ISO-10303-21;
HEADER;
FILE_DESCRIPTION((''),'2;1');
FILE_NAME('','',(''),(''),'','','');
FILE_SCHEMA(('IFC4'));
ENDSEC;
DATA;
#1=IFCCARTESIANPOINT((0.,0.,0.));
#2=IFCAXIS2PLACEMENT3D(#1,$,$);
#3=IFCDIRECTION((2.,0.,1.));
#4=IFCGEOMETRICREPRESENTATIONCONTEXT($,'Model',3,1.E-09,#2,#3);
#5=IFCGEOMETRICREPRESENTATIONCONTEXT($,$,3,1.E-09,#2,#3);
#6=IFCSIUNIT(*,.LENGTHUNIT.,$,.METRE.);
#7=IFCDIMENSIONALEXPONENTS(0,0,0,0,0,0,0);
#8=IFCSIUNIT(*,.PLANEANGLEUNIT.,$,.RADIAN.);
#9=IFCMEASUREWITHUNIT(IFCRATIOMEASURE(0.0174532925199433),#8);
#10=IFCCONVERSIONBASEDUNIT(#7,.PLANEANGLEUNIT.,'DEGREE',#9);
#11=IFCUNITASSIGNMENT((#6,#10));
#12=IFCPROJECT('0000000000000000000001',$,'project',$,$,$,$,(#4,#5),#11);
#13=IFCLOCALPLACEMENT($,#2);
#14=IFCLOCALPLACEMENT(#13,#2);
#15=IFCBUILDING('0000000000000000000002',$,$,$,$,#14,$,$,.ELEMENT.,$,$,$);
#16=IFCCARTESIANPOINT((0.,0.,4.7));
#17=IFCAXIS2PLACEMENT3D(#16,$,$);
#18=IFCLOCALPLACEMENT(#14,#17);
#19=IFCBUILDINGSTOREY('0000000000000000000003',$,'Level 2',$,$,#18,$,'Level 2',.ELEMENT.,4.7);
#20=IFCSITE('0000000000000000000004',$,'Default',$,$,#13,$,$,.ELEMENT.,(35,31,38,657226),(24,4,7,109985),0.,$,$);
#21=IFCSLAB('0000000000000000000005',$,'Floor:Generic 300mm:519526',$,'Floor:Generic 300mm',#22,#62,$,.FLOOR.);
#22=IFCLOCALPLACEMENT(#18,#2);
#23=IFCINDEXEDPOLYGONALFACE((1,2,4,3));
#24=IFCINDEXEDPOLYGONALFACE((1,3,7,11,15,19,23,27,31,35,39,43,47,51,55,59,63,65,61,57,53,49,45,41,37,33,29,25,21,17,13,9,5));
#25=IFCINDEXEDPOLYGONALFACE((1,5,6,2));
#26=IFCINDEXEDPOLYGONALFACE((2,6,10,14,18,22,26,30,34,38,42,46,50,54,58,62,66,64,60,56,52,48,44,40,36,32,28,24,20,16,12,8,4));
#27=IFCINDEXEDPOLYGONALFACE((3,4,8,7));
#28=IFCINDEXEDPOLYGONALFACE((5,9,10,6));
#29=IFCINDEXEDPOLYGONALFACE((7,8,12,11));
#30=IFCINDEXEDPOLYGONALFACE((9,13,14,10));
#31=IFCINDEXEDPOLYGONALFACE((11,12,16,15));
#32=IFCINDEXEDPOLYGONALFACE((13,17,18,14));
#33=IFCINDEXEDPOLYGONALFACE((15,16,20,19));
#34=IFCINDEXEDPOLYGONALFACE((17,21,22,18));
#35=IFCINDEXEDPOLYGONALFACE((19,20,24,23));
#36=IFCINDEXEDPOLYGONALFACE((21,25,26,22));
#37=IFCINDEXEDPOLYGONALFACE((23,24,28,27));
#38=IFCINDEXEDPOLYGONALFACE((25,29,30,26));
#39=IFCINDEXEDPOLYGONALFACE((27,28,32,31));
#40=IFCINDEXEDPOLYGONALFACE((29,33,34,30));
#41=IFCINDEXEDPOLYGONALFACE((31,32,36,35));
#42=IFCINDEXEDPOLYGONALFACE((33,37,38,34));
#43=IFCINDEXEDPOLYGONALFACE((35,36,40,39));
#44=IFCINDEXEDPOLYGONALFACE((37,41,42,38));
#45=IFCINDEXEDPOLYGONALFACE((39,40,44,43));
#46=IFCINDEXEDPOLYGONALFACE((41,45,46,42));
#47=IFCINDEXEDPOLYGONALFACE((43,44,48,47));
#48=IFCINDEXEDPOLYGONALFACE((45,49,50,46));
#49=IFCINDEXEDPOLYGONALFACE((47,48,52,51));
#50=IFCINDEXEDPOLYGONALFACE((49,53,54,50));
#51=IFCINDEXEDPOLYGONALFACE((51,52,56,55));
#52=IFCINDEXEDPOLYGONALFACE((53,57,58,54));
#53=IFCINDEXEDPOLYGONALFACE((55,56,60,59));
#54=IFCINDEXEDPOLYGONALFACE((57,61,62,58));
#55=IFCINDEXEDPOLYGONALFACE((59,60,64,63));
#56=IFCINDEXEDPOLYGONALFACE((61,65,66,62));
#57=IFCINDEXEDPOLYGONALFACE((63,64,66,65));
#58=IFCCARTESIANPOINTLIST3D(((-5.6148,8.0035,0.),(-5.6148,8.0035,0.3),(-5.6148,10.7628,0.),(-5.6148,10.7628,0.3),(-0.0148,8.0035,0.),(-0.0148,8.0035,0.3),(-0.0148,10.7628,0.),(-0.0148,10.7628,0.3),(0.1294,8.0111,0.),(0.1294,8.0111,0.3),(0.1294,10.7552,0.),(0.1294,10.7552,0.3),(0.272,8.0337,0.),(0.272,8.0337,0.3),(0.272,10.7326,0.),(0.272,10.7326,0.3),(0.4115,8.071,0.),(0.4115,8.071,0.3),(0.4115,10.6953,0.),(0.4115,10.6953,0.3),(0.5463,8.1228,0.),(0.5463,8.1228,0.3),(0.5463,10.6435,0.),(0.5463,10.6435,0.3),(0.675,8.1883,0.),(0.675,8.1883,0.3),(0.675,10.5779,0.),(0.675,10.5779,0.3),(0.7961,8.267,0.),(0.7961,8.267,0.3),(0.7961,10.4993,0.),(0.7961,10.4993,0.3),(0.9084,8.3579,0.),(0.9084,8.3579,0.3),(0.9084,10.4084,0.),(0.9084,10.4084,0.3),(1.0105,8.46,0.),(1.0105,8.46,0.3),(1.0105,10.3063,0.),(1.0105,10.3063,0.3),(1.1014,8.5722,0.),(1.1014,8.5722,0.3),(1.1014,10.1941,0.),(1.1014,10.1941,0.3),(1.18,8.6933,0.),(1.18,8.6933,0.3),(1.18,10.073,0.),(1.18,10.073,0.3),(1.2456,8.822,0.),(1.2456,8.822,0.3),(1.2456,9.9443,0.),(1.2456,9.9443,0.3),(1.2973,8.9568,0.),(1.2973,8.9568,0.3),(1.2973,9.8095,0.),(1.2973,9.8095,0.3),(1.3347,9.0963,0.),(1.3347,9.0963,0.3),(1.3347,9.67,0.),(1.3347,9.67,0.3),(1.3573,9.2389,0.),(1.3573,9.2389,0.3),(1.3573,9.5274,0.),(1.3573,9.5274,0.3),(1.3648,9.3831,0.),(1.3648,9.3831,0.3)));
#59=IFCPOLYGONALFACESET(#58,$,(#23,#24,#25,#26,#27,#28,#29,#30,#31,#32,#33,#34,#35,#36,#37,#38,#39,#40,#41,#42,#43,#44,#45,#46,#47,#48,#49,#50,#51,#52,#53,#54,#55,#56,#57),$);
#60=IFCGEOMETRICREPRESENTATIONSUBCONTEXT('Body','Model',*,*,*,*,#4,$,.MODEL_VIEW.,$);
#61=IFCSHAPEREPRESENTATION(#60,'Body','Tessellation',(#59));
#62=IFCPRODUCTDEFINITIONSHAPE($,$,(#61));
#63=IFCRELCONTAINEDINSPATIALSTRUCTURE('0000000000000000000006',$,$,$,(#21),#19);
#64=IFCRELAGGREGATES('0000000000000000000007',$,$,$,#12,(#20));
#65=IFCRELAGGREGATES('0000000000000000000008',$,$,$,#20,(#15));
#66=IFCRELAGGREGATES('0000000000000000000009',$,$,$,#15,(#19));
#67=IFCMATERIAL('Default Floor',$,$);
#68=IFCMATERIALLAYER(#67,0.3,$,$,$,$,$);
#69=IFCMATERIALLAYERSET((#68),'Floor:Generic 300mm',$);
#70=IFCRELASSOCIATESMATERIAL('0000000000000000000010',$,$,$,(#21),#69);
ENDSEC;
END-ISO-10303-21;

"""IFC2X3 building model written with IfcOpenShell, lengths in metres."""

from ifc_helpers import new_model, entity, si_unit, converted_unit, direction, frame, frame_2d, origin, place, context, subcontext, project, spatial, polyline, circle_curve, parameter, trimmed, segment, composite_curve, outline, extrude, material, layer, layer_set, layer_usage, element, save


model = new_model("IFC2X3")

# Units and contexts
model_context = context("Model", 3, precision=1e-09, world=origin(), true_north=direction((2.0, 0.0, 1.0)))
context_of_model = context(None, 3, precision=1e-09, world=origin(), true_north=direction((2.0, 0.0, 1.0)))
body_context = subcontext(model_context, "Body", "Model", "MODEL_VIEW")
ifc_project = project(units=[si_unit("LENGTHUNIT", "METRE"), converted_unit("PLANEANGLEUNIT", "DEGREE", entity("IfcRatioMeasure", 0.0174532925199433), si_unit("PLANEANGLEUNIT", "RADIAN"), dimensions=[0, 0, 0, 0, 0, 0, 0])], contexts=[model_context, context_of_model])

# Site, building, storey
site_placement = place(None, origin())
site = spatial("IfcSite", under=ifc_project, at=site_placement, Name="Default", CompositionType="ELEMENT", RefLatitude=(35, 31, 38, 657226), RefLongitude=(24, 4, 7, 109985), RefElevation=0.0)
building_placement = place(site_placement, origin())
building = spatial("IfcBuilding", under=site, at=building_placement, CompositionType="ELEMENT")
storey_placement = place(building_placement, frame((0.0, 0.0, 4.7)))
storey = spatial("IfcBuildingStorey", under=building, at=storey_placement, Name="Level 2", LongName="Level 2", CompositionType="ELEMENT", Elevation=4.7)

# Slab
ifc_material = material(Name="Default Floor")
ifc_layer = layer(ifc_material, 0.3)
ifc_layer_set = layer_set([ifc_layer], Name="Floor:Generic 300mm")
ifc_layer_usage = layer_usage(ifc_layer_set, "AXIS3", "POSITIVE", 0.0)
slab_placement = place(storey_placement, origin())
element("IfcSlab", 1, at=slab_placement, inside=storey, material=ifc_layer_usage, Name="Floor:Generic 300mm:519526", ObjectType="Floor:Generic 300mm", PredefinedType="FLOOR", context=body_context, shape_type="SweptSolid", body=[
    extrude(outline(composite_curve([segment(polyline([(-1.3796, -2.8), (1.3796, -2.8)]), True, "CONTINUOUS"), segment(polyline([(1.3796, -2.8), (1.3796, 2.8)]), True, "CONTINUOUS"), segment(trimmed(circle_curve(frame_2d((0.0, 2.8), x_axis=(1.0, 0.0)), 1.3796), [parameter(0.0)], [parameter(180.0)], True, "PARAMETER"), True, "CONTINUOUS"), segment(polyline([(-1.3796, 2.8), (-1.3796, -2.8)]), True, "CONTINUOUS")], self_intersect=False)), frame((-2.8148, 9.3831, 0.3), z_axis=(0.0, 0.0, -1.0), x_axis=(0.0, 1.0, 0.0)), (0.0, 0.0, 1.0), 0.3),
])

save(model, "model.ifc")
